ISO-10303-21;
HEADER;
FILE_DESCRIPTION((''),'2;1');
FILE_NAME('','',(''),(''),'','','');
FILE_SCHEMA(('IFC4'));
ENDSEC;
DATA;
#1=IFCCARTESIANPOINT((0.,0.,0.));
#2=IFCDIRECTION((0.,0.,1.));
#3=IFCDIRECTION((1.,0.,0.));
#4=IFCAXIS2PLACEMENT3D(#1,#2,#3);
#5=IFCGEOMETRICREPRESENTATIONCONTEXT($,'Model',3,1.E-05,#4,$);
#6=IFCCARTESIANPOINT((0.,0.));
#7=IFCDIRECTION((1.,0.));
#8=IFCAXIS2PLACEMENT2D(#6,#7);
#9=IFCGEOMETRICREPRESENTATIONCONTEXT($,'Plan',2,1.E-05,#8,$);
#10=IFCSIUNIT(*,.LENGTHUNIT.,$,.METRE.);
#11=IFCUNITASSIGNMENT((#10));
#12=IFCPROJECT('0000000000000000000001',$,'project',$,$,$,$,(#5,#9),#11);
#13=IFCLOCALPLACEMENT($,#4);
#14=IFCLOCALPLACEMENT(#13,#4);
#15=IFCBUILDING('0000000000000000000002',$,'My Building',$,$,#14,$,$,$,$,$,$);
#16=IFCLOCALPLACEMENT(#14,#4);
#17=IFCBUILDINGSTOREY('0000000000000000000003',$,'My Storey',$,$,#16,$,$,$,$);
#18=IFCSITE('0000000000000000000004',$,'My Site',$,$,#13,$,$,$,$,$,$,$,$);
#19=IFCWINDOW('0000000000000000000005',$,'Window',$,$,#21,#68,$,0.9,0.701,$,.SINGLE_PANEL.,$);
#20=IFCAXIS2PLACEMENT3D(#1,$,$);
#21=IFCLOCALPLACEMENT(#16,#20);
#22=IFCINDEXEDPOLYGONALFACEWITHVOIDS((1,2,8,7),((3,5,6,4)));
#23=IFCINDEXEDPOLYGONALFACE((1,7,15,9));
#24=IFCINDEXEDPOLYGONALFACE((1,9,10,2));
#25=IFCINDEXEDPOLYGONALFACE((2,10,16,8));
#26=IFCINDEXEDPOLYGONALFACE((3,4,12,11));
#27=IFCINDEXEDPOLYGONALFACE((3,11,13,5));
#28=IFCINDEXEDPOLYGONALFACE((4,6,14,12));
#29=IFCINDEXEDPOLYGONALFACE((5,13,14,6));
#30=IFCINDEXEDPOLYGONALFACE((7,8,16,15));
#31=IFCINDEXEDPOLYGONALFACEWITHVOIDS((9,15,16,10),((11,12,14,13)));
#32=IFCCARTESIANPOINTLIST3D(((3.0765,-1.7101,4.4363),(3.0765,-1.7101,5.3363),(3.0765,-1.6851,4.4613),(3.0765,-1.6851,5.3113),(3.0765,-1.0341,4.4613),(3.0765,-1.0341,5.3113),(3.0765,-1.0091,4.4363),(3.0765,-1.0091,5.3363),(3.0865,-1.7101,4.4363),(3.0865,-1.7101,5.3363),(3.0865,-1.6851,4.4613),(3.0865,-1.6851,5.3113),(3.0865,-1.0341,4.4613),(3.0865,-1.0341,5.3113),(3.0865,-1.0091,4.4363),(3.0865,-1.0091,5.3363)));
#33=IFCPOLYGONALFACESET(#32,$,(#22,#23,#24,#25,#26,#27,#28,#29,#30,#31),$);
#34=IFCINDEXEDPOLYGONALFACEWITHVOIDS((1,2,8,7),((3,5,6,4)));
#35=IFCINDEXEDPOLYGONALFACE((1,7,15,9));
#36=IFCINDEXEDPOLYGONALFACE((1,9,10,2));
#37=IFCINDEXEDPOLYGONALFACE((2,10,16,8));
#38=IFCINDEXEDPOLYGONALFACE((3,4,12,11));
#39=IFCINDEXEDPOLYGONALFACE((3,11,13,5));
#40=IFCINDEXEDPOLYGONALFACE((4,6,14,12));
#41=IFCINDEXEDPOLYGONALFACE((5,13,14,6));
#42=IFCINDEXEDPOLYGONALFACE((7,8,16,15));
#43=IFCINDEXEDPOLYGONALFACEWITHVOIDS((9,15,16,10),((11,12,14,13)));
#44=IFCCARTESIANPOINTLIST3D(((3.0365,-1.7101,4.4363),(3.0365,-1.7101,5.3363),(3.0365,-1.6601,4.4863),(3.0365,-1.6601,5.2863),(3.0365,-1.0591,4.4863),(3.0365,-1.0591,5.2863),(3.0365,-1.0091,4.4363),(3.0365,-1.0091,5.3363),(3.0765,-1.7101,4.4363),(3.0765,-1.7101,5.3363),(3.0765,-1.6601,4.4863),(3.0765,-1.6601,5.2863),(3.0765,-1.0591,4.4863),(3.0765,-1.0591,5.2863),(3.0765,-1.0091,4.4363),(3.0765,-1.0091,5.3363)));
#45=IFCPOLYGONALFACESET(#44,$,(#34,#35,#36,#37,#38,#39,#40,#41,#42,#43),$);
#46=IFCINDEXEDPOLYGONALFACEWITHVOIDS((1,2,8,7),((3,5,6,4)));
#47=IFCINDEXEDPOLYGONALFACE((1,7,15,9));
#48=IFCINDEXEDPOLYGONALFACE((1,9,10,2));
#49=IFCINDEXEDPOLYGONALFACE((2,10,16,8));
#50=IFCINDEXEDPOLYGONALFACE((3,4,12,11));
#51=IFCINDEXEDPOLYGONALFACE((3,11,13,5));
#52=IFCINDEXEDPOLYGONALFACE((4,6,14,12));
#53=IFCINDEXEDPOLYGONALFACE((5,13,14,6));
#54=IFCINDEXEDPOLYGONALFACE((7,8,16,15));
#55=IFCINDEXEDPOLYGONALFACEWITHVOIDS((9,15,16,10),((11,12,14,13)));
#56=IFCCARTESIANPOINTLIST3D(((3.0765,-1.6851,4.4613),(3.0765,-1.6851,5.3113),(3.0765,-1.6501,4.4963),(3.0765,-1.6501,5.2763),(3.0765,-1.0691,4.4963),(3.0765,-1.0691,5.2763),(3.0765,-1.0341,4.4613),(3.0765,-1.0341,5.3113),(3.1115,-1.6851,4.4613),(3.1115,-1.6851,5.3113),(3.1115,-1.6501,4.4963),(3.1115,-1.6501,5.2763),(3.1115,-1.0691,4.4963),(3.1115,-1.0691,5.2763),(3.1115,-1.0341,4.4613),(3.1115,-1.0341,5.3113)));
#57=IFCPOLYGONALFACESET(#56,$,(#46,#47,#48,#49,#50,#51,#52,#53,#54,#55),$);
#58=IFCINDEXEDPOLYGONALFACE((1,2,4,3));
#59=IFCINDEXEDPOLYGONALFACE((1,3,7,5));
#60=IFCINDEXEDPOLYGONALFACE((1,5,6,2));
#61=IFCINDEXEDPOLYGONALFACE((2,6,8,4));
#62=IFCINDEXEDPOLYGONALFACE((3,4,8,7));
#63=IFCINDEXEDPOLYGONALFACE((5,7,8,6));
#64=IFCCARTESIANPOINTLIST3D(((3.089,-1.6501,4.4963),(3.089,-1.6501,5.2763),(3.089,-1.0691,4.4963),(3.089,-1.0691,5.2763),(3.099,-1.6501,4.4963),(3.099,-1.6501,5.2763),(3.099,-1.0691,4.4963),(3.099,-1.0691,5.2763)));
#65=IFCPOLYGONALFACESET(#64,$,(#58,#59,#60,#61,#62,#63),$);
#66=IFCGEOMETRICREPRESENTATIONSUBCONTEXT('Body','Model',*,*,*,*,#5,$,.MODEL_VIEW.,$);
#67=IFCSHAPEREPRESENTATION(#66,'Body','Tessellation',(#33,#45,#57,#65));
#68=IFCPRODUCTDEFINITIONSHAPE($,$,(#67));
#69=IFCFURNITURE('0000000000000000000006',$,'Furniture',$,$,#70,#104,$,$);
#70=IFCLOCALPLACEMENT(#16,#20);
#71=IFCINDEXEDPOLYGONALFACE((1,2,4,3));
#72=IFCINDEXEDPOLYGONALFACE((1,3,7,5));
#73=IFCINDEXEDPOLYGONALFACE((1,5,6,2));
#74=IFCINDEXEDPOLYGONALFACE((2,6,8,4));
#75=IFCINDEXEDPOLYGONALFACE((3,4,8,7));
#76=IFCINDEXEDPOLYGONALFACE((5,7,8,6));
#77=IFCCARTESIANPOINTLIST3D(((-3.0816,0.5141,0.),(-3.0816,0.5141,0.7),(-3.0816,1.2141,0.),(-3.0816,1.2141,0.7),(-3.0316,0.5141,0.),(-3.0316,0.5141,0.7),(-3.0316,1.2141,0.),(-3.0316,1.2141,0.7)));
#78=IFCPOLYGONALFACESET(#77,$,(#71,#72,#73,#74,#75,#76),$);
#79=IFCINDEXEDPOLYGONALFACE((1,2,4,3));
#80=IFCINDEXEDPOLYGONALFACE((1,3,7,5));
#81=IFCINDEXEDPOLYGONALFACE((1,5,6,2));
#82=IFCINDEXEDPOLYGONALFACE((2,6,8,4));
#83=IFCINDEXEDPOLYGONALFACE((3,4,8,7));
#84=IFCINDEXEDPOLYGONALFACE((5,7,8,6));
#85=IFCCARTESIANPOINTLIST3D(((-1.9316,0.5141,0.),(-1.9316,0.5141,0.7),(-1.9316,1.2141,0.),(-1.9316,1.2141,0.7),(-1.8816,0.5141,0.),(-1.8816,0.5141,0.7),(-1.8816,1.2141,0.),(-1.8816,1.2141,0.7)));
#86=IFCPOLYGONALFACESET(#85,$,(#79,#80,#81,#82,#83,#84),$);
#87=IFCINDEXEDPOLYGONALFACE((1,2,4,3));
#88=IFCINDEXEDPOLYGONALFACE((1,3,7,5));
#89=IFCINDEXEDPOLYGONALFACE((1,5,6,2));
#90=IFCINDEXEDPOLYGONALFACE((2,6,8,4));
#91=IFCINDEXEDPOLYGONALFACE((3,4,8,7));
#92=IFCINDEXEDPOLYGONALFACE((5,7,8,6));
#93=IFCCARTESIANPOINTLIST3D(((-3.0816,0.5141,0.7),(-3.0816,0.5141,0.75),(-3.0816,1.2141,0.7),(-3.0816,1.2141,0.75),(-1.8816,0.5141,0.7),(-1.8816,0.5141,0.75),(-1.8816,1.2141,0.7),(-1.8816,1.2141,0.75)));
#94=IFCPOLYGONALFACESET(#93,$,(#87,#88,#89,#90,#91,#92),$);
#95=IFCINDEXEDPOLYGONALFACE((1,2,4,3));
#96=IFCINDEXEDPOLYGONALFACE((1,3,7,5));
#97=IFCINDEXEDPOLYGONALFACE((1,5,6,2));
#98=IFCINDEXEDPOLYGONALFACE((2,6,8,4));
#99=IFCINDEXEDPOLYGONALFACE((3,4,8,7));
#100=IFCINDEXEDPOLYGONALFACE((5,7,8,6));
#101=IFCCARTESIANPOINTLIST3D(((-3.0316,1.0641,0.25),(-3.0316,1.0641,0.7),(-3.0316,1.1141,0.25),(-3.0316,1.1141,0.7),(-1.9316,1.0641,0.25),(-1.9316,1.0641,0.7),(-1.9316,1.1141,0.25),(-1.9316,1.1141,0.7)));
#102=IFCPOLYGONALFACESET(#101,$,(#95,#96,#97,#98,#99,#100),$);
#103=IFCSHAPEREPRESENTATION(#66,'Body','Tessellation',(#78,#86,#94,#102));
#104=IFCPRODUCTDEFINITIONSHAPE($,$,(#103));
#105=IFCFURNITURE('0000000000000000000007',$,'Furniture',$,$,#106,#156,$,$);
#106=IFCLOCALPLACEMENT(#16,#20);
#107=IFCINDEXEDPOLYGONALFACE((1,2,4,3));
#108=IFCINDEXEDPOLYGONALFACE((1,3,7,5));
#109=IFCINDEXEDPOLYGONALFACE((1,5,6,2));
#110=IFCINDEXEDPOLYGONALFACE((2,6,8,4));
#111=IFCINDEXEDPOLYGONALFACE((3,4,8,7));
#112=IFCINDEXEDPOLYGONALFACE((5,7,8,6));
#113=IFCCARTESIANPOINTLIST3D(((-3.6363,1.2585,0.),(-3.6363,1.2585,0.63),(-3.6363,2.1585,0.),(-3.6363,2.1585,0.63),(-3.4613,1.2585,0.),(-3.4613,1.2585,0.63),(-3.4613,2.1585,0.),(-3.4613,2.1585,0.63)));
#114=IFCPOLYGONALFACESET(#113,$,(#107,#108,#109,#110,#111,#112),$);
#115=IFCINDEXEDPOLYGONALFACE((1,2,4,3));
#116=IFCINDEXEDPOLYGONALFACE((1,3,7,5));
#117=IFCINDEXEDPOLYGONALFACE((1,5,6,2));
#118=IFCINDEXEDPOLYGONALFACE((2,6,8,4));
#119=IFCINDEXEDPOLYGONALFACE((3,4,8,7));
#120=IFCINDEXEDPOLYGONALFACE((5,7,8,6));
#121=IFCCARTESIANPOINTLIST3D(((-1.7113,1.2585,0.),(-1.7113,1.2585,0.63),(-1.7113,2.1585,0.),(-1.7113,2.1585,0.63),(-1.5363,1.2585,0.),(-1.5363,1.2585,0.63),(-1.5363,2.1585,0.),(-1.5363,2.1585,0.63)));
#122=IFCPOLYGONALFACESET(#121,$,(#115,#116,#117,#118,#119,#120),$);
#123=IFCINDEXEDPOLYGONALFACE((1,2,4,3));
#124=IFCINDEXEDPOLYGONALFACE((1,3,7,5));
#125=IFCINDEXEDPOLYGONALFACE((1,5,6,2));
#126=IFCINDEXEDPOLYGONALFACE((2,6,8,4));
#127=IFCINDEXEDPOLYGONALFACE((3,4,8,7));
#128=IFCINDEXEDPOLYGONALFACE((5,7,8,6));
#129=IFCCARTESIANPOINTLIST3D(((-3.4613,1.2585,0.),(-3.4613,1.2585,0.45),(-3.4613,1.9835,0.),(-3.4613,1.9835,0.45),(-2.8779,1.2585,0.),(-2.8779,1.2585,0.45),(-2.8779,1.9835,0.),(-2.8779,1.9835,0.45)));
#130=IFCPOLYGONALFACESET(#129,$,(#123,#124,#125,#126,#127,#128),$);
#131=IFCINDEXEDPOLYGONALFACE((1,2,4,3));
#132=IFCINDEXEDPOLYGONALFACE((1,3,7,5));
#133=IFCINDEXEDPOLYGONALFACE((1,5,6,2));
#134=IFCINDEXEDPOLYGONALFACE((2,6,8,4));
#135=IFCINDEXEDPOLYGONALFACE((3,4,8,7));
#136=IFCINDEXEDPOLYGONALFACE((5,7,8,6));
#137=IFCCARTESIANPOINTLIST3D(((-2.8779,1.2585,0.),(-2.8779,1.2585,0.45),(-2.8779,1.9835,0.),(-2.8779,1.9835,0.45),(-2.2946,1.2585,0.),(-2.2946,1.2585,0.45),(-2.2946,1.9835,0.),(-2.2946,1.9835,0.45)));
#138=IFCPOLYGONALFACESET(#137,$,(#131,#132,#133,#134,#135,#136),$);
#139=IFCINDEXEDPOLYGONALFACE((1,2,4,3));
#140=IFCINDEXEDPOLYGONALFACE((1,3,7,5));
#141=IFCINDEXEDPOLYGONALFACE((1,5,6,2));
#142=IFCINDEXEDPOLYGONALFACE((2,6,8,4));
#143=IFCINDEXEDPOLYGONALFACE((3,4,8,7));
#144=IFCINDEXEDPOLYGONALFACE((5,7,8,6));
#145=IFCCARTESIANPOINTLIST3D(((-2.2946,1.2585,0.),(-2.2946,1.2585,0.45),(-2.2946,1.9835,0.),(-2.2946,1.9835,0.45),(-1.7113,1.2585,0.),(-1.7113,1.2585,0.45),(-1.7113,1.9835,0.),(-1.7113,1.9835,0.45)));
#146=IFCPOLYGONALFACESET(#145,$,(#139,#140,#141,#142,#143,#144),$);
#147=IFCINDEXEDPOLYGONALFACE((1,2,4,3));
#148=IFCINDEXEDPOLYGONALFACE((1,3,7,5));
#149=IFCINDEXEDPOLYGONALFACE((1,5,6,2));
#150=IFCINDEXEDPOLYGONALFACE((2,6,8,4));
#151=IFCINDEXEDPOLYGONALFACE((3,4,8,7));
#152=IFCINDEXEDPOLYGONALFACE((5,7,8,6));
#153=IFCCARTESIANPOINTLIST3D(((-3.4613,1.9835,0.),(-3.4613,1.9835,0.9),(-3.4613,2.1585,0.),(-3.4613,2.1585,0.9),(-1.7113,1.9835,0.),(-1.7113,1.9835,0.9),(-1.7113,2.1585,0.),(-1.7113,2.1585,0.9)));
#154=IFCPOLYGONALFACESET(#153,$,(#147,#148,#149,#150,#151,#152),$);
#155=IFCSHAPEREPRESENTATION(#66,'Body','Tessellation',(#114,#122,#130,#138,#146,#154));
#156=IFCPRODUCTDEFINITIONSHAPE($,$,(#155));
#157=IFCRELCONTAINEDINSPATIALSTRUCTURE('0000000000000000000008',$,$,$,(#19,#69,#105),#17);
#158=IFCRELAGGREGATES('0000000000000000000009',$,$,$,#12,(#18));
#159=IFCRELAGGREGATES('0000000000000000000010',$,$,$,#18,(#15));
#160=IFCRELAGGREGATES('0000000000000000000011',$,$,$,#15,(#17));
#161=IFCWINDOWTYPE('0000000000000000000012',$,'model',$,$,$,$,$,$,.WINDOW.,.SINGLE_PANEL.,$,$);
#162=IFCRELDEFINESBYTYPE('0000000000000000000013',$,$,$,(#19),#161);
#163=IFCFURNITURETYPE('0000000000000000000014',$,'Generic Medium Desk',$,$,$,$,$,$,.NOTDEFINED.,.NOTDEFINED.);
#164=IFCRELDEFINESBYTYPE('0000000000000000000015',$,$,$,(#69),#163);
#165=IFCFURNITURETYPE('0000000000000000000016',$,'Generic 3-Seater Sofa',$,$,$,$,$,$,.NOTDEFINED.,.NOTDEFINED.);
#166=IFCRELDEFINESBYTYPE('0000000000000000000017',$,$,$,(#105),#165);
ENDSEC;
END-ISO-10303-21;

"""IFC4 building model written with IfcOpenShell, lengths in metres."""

from ifc_helpers import new_model, entity, si_unit, frame, origin_with_axes, origin_2d_with_axis, place, context, subcontext, project, spatial, line, indexed_curve, outline, extrude, shape, source, transform, mapped, type_object, type_shapes, element, save


model = new_model("IFC4")

# Units and contexts
model_context = context("Model", 3, precision=1e-05, world=origin_with_axes())
plan_context = context("Plan", 2, precision=1e-05, world=origin_2d_with_axis())
body_context_1 = subcontext(model_context, "Body", "Model", "MODEL_VIEW")
body_context_2 = subcontext(plan_context, "Body", "Plan", "PLAN_VIEW")
ifc_project = project(units=[si_unit("LENGTHUNIT", "METRE")], contexts=[model_context, plan_context])

# Site, building, storey
site_placement = place(None, origin_with_axes())
site = spatial("IfcSite", under=ifc_project, at=site_placement, Name="My Site")
building_placement = place(site_placement, origin_with_axes())
building = spatial("IfcBuilding", under=site, at=building_placement, Name="My Building")
storey_placement = place(building_placement, origin_with_axes())
storey = spatial("IfcBuildingStorey", under=building, at=storey_placement, Name="My Storey")

# Window
window_type_1 = type_object("IfcWindowType", Name="model", PartitioningType="SINGLE_PANEL", PredefinedType="WINDOW")
shared_shape_1 = source(origin_with_axes(), body_context_1, "Body", "SweptSolid", [
    extrude(outline(indexed_curve([(0.0, 0.0), (0.701, 0.0), (0.701, 0.9), (0.0, 0.9)], segments=[line(1, 2, 3, 4, 1)]), holes=[indexed_curve([(0.025, 0.025), (0.676, 0.025), (0.676, 0.875), (0.025, 0.875)], segments=[line(1, 2, 3, 4, 1)])]), frame((0.0, 0.09, 0.0), z_axis=(0.0, -1.0, 0.0), x_axis=(1.0, 0.0, 0.0)), (0.0, 0.0, -1.0), 0.01),
    extrude(outline(indexed_curve([(0.0, 0.0), (0.701, 0.0), (0.701, 0.9), (0.0, 0.9)], segments=[line(1, 2, 3, 4, 1)]), holes=[indexed_curve([(0.05, 0.05), (0.651, 0.05), (0.651, 0.85), (0.05, 0.85)], segments=[line(1, 2, 3, 4, 1)])]), frame((0.0, 0.05, 0.0), z_axis=(0.0, -1.0, 0.0), x_axis=(1.0, 0.0, 0.0)), (0.0, 0.0, -1.0), 0.04),
    extrude(outline(indexed_curve([(0.0, 0.0), (0.651, 0.0), (0.651, 0.85), (0.0, 0.85)], segments=[line(1, 2, 3, 4, 1)]), holes=[indexed_curve([(0.035, 0.035), (0.616, 0.035), (0.616, 0.815), (0.035, 0.815)], segments=[line(1, 2, 3, 4, 1)])]), frame((0.025, 0.09, 0.025), z_axis=(0.0, -1.0, 0.0), x_axis=(1.0, 0.0, 0.0)), (0.0, 0.0, -1.0), 0.035),
    extrude(outline(indexed_curve([(0.035, 0.035), (0.616, 0.035), (0.616, 0.815), (0.035, 0.815)], segments=[line(1, 2, 3, 4, 1)])), frame((0.025, 0.1025, 0.025), z_axis=(0.0, -1.0, 0.0), x_axis=(1.0, 0.0, 0.0)), (0.0, 0.0, -1.0), 0.01),
])
shared_shape_2 = source(origin_with_axes(), body_context_2, "Body", "Curve2D", [
    entity("IfcIndexedPolyCurve", entity("IfcCartesianPointList2D", [[0.05, 0.05], [0.651, 0.05]])),
    entity("IfcIndexedPolyCurve", entity("IfcCartesianPointList2D", [[0.0, 0.1], [0.025, 0.1], [0.025, 0.09], [0.05, 0.09], [0.05, 0.05], [0.0, 0.05]]), [entity("IfcLineIndex", [1, 2, 3, 4, 5, 6, 1])]),
    entity("IfcIndexedPolyCurve", entity("IfcCartesianPointList2D", [[0.701, 0.1], [0.676, 0.1], [0.676, 0.09], [0.651, 0.09], [0.651, 0.05], [0.701, 0.05]]), [entity("IfcLineIndex", [1, 2, 3, 4, 5, 6, 1])]),
    entity("IfcIndexedPolyCurve", entity("IfcCartesianPointList2D", [[0.025, 0.09], [0.06, 0.09], [0.06, 0.125], [0.025, 0.125]]), [entity("IfcLineIndex", [1, 2, 3, 4, 1])]),
    entity("IfcIndexedPolyCurve", entity("IfcCartesianPointList2D", [[0.676, 0.09], [0.641, 0.09], [0.641, 0.125], [0.676, 0.125]]), [entity("IfcLineIndex", [1, 2, 3, 4, 1])]),
    entity("IfcIndexedPolyCurve", entity("IfcCartesianPointList2D", [[0.06, 0.09], [0.641, 0.09]])),
    entity("IfcIndexedPolyCurve", entity("IfcCartesianPointList2D", [[0.06, 0.125], [0.641, 0.125]])),
    entity("IfcIndexedPolyCurve", entity("IfcCartesianPointList2D", [[0.06, 0.1075], [0.641, 0.1075]])),
])
type_shapes(window_type_1, [shared_shape_1, shared_shape_2])
for number, where, z_axis, x_axis, name in (
    (1, (2.9865, -1.0091, 4.4363), (0.0, 0.0, 1.0), (0.0, -1.0, 0.0), "Window"),
):
    element("IfcWindow", number, at=place(storey_placement, frame(where, z_axis=z_axis, x_axis=x_axis)), inside=storey, type_object=window_type_1, Name=name, OverallHeight=0.9, OverallWidth=0.701, PartitioningType="SINGLE_PANEL", shapes=[
        shape(body_context_1, "Body", "MappedRepresentation", [mapped(shared_shape_1, transform((0.0, 0.0, 0.0), x_axis=(1.0, 0.0, 0.0), y_axis=(0.0, 1.0, 0.0), z_axis=(0.0, 0.0, 1.0), scale=1.0))]),
        shape(body_context_2, "Body", "MappedRepresentation", [mapped(shared_shape_2, transform((0.0, 0.0, 0.0), x_axis=(1.0, 0.0, 0.0), y_axis=(0.0, 1.0, 0.0), z_axis=(0.0, 0.0, 1.0), scale=1.0))]),
    ])

# Furniture
furniture_type_1 = type_object("IfcFurnitureType", Name="Generic Medium Desk", AssemblyPlace="NOTDEFINED", PredefinedType="NOTDEFINED")
shared_shape_3 = source(origin_with_axes(), body_context_1, "Body", "SweptSolid", [
    extrude(outline(indexed_curve([(0.0, 0.0), (0.05, 0.0), (0.05, 0.7), (0.0, 0.7)], segments=[line(1, 2, 3, 4, 1)])), origin_with_axes(), (0.0, 0.0, 1.0), 0.7),
    extrude(outline(indexed_curve([(0.0, 0.0), (0.05, 0.0), (0.05, 0.7), (0.0, 0.7)], segments=[line(1, 2, 3, 4, 1)])), frame((1.15, 0.0, 0.0), z_axis=(0.0, 0.0, 1.0), x_axis=(1.0, 0.0, 0.0)), (0.0, 0.0, 1.0), 0.7),
    extrude(outline(indexed_curve([(0.0, 0.0), (1.2, 0.0), (1.2, 0.7), (0.0, 0.7)], segments=[line(1, 2, 3, 4, 1)])), frame((0.0, 0.0, 0.7), z_axis=(0.0, 0.0, 1.0), x_axis=(1.0, 0.0, 0.0)), (0.0, 0.0, 1.0), 0.05),
    extrude(outline(indexed_curve([(0.05, 0.55), (1.15, 0.55), (1.15, 0.6), (0.05, 0.6)], segments=[line(1, 2, 3, 4, 1)])), frame((0.0, 0.0, 0.25), z_axis=(0.0, 0.0, 1.0), x_axis=(1.0, 0.0, 0.0)), (0.0, 0.0, 1.0), 0.45),
])
shared_shape_4 = source(origin_with_axes(), body_context_2, "Body", "Curve2D", [
    entity("IfcIndexedPolyCurve", entity("IfcCartesianPointList2D", [[0.0, 0.0], [1.2, 0.0], [1.2, 0.7], [0.0, 0.7]]), [entity("IfcLineIndex", [1, 2, 3, 4, 1])]),
])
type_shapes(furniture_type_1, [shared_shape_3, shared_shape_4])
furniture_1_placement = place(storey_placement, frame((-3.0816, 0.5141, 0.0), z_axis=(0.0, 0.0, 1.0), x_axis=(1.0, 0.0, 0.0)))
element("IfcFurniture", 2, at=furniture_1_placement, inside=storey, type_object=furniture_type_1, Name="Furniture", shapes=[
    shape(body_context_1, "Body", "MappedRepresentation", [mapped(shared_shape_3, transform((0.0, 0.0, 0.0), x_axis=(1.0, 0.0, 0.0), y_axis=(0.0, 1.0, 0.0), z_axis=(0.0, 0.0, 1.0), scale=1.0))]),
    shape(body_context_2, "Body", "MappedRepresentation", [mapped(shared_shape_4, transform((0.0, 0.0, 0.0), x_axis=(1.0, 0.0, 0.0), y_axis=(0.0, 1.0, 0.0), z_axis=(0.0, 0.0, 1.0), scale=1.0))]),
])
furniture_type_2 = type_object("IfcFurnitureType", Name="Generic 3-Seater Sofa", AssemblyPlace="NOTDEFINED", PredefinedType="NOTDEFINED")
shared_shape_5 = source(origin_with_axes(), body_context_1, "Body", "SweptSolid", [
    extrude(outline(indexed_curve([(0.0, 0.0), (0.175, 0.0), (0.175, 0.9), (0.0, 0.9)], segments=[line(1, 2, 3, 4, 1)])), frame((-1.05, -0.9, 0.0), z_axis=(0.0, 0.0, 1.0), x_axis=(1.0, 0.0, 0.0)), (0.0, 0.0, 1.0), 0.63),
    extrude(outline(indexed_curve([(0.0, 0.0), (0.175, 0.0), (0.175, 0.9), (0.0, 0.9)], segments=[line(1, 2, 3, 4, 1)])), frame((0.875, -0.9, 0.0), z_axis=(0.0, 0.0, 1.0), x_axis=(1.0, 0.0, 0.0)), (0.0, 0.0, 1.0), 0.63),
    extrude(outline(indexed_curve([(0.175, 0.0), (0.7583, 0.0), (0.7583, 0.725), (0.175, 0.725)], segments=[line(1, 2, 3, 4, 1)])), frame((-1.05, -0.9, 0.0), z_axis=(0.0, 0.0, 1.0), x_axis=(1.0, 0.0, 0.0)), (0.0, 0.0, 1.0), 0.45),
    extrude(outline(indexed_curve([(0.7583, 0.0), (1.3417, 0.0), (1.3417, 0.725), (0.7583, 0.725)], segments=[line(1, 2, 3, 4, 1)])), frame((-1.05, -0.9, 0.0), z_axis=(0.0, 0.0, 1.0), x_axis=(1.0, 0.0, 0.0)), (0.0, 0.0, 1.0), 0.45),
    extrude(outline(indexed_curve([(1.3417, 0.0), (1.925, 0.0), (1.925, 0.725), (1.3417, 0.725)], segments=[line(1, 2, 3, 4, 1)])), frame((-1.05, -0.9, 0.0), z_axis=(0.0, 0.0, 1.0), x_axis=(1.0, 0.0, 0.0)), (0.0, 0.0, 1.0), 0.45),
    extrude(outline(indexed_curve([(0.175, 0.725), (1.925, 0.725), (1.925, 0.9), (0.175, 0.9)], segments=[line(1, 2, 3, 4, 1)])), frame((-1.05, -0.9, 0.0), z_axis=(0.0, 0.0, 1.0), x_axis=(1.0, 0.0, 0.0)), (0.0, 0.0, 1.0), 0.9),
])
shared_shape_6 = source(origin_with_axes(), body_context_2, "Body", "Curve2D", [
    entity("IfcIndexedPolyCurve", entity("IfcCartesianPointList2D", [[-1.05, -0.9], [-0.875, -0.9], [-0.875, 0.0], [-1.05, 0.0]]), [entity("IfcLineIndex", [1, 2, 3, 4, 1])]),
    entity("IfcIndexedPolyCurve", entity("IfcCartesianPointList2D", [[0.875, -0.9], [1.05, -0.9], [1.05, 0.0], [0.875, 0.0]]), [entity("IfcLineIndex", [1, 2, 3, 4, 1])]),
    entity("IfcIndexedPolyCurve", entity("IfcCartesianPointList2D", [[-0.875, -0.9], [-0.2917, -0.9], [-0.2917, -0.175], [-0.875, -0.175]]), [entity("IfcLineIndex", [1, 2, 3, 4, 1])]),
    entity("IfcIndexedPolyCurve", entity("IfcCartesianPointList2D", [[-0.2917, -0.9], [0.2917, -0.9], [0.2917, -0.175], [-0.2917, -0.175]]), [entity("IfcLineIndex", [1, 2, 3, 4, 1])]),
    entity("IfcIndexedPolyCurve", entity("IfcCartesianPointList2D", [[0.2917, -0.9], [0.875, -0.9], [0.875, -0.175], [0.2917, -0.175]]), [entity("IfcLineIndex", [1, 2, 3, 4, 1])]),
    entity("IfcIndexedPolyCurve", entity("IfcCartesianPointList2D", [[-0.875, -0.175], [0.875, -0.175], [0.875, 0.0], [-0.875, 0.0]]), [entity("IfcLineIndex", [1, 2, 3, 4, 1])]),
])
type_shapes(furniture_type_2, [shared_shape_5, shared_shape_6])
furniture_2_placement = place(storey_placement, frame((-2.5863, 2.1585, 0.0), z_axis=(0.0, 0.0, 1.0), x_axis=(1.0, 0.0, 0.0)))
element("IfcFurniture", 3, at=furniture_2_placement, inside=storey, type_object=furniture_type_2, Name="Furniture", shapes=[
    shape(body_context_1, "Body", "MappedRepresentation", [mapped(shared_shape_5, transform((0.0, 0.0, 0.0), x_axis=(1.0, 0.0, 0.0), y_axis=(0.0, 1.0, 0.0), z_axis=(0.0, 0.0, 1.0), scale=1.0))]),
    shape(body_context_2, "Body", "MappedRepresentation", [mapped(shared_shape_6, transform((0.0, 0.0, 0.0), x_axis=(1.0, 0.0, 0.0), y_axis=(0.0, 1.0, 0.0), z_axis=(0.0, 0.0, 1.0), scale=1.0))]),
])

save(model, "model.ifc")
